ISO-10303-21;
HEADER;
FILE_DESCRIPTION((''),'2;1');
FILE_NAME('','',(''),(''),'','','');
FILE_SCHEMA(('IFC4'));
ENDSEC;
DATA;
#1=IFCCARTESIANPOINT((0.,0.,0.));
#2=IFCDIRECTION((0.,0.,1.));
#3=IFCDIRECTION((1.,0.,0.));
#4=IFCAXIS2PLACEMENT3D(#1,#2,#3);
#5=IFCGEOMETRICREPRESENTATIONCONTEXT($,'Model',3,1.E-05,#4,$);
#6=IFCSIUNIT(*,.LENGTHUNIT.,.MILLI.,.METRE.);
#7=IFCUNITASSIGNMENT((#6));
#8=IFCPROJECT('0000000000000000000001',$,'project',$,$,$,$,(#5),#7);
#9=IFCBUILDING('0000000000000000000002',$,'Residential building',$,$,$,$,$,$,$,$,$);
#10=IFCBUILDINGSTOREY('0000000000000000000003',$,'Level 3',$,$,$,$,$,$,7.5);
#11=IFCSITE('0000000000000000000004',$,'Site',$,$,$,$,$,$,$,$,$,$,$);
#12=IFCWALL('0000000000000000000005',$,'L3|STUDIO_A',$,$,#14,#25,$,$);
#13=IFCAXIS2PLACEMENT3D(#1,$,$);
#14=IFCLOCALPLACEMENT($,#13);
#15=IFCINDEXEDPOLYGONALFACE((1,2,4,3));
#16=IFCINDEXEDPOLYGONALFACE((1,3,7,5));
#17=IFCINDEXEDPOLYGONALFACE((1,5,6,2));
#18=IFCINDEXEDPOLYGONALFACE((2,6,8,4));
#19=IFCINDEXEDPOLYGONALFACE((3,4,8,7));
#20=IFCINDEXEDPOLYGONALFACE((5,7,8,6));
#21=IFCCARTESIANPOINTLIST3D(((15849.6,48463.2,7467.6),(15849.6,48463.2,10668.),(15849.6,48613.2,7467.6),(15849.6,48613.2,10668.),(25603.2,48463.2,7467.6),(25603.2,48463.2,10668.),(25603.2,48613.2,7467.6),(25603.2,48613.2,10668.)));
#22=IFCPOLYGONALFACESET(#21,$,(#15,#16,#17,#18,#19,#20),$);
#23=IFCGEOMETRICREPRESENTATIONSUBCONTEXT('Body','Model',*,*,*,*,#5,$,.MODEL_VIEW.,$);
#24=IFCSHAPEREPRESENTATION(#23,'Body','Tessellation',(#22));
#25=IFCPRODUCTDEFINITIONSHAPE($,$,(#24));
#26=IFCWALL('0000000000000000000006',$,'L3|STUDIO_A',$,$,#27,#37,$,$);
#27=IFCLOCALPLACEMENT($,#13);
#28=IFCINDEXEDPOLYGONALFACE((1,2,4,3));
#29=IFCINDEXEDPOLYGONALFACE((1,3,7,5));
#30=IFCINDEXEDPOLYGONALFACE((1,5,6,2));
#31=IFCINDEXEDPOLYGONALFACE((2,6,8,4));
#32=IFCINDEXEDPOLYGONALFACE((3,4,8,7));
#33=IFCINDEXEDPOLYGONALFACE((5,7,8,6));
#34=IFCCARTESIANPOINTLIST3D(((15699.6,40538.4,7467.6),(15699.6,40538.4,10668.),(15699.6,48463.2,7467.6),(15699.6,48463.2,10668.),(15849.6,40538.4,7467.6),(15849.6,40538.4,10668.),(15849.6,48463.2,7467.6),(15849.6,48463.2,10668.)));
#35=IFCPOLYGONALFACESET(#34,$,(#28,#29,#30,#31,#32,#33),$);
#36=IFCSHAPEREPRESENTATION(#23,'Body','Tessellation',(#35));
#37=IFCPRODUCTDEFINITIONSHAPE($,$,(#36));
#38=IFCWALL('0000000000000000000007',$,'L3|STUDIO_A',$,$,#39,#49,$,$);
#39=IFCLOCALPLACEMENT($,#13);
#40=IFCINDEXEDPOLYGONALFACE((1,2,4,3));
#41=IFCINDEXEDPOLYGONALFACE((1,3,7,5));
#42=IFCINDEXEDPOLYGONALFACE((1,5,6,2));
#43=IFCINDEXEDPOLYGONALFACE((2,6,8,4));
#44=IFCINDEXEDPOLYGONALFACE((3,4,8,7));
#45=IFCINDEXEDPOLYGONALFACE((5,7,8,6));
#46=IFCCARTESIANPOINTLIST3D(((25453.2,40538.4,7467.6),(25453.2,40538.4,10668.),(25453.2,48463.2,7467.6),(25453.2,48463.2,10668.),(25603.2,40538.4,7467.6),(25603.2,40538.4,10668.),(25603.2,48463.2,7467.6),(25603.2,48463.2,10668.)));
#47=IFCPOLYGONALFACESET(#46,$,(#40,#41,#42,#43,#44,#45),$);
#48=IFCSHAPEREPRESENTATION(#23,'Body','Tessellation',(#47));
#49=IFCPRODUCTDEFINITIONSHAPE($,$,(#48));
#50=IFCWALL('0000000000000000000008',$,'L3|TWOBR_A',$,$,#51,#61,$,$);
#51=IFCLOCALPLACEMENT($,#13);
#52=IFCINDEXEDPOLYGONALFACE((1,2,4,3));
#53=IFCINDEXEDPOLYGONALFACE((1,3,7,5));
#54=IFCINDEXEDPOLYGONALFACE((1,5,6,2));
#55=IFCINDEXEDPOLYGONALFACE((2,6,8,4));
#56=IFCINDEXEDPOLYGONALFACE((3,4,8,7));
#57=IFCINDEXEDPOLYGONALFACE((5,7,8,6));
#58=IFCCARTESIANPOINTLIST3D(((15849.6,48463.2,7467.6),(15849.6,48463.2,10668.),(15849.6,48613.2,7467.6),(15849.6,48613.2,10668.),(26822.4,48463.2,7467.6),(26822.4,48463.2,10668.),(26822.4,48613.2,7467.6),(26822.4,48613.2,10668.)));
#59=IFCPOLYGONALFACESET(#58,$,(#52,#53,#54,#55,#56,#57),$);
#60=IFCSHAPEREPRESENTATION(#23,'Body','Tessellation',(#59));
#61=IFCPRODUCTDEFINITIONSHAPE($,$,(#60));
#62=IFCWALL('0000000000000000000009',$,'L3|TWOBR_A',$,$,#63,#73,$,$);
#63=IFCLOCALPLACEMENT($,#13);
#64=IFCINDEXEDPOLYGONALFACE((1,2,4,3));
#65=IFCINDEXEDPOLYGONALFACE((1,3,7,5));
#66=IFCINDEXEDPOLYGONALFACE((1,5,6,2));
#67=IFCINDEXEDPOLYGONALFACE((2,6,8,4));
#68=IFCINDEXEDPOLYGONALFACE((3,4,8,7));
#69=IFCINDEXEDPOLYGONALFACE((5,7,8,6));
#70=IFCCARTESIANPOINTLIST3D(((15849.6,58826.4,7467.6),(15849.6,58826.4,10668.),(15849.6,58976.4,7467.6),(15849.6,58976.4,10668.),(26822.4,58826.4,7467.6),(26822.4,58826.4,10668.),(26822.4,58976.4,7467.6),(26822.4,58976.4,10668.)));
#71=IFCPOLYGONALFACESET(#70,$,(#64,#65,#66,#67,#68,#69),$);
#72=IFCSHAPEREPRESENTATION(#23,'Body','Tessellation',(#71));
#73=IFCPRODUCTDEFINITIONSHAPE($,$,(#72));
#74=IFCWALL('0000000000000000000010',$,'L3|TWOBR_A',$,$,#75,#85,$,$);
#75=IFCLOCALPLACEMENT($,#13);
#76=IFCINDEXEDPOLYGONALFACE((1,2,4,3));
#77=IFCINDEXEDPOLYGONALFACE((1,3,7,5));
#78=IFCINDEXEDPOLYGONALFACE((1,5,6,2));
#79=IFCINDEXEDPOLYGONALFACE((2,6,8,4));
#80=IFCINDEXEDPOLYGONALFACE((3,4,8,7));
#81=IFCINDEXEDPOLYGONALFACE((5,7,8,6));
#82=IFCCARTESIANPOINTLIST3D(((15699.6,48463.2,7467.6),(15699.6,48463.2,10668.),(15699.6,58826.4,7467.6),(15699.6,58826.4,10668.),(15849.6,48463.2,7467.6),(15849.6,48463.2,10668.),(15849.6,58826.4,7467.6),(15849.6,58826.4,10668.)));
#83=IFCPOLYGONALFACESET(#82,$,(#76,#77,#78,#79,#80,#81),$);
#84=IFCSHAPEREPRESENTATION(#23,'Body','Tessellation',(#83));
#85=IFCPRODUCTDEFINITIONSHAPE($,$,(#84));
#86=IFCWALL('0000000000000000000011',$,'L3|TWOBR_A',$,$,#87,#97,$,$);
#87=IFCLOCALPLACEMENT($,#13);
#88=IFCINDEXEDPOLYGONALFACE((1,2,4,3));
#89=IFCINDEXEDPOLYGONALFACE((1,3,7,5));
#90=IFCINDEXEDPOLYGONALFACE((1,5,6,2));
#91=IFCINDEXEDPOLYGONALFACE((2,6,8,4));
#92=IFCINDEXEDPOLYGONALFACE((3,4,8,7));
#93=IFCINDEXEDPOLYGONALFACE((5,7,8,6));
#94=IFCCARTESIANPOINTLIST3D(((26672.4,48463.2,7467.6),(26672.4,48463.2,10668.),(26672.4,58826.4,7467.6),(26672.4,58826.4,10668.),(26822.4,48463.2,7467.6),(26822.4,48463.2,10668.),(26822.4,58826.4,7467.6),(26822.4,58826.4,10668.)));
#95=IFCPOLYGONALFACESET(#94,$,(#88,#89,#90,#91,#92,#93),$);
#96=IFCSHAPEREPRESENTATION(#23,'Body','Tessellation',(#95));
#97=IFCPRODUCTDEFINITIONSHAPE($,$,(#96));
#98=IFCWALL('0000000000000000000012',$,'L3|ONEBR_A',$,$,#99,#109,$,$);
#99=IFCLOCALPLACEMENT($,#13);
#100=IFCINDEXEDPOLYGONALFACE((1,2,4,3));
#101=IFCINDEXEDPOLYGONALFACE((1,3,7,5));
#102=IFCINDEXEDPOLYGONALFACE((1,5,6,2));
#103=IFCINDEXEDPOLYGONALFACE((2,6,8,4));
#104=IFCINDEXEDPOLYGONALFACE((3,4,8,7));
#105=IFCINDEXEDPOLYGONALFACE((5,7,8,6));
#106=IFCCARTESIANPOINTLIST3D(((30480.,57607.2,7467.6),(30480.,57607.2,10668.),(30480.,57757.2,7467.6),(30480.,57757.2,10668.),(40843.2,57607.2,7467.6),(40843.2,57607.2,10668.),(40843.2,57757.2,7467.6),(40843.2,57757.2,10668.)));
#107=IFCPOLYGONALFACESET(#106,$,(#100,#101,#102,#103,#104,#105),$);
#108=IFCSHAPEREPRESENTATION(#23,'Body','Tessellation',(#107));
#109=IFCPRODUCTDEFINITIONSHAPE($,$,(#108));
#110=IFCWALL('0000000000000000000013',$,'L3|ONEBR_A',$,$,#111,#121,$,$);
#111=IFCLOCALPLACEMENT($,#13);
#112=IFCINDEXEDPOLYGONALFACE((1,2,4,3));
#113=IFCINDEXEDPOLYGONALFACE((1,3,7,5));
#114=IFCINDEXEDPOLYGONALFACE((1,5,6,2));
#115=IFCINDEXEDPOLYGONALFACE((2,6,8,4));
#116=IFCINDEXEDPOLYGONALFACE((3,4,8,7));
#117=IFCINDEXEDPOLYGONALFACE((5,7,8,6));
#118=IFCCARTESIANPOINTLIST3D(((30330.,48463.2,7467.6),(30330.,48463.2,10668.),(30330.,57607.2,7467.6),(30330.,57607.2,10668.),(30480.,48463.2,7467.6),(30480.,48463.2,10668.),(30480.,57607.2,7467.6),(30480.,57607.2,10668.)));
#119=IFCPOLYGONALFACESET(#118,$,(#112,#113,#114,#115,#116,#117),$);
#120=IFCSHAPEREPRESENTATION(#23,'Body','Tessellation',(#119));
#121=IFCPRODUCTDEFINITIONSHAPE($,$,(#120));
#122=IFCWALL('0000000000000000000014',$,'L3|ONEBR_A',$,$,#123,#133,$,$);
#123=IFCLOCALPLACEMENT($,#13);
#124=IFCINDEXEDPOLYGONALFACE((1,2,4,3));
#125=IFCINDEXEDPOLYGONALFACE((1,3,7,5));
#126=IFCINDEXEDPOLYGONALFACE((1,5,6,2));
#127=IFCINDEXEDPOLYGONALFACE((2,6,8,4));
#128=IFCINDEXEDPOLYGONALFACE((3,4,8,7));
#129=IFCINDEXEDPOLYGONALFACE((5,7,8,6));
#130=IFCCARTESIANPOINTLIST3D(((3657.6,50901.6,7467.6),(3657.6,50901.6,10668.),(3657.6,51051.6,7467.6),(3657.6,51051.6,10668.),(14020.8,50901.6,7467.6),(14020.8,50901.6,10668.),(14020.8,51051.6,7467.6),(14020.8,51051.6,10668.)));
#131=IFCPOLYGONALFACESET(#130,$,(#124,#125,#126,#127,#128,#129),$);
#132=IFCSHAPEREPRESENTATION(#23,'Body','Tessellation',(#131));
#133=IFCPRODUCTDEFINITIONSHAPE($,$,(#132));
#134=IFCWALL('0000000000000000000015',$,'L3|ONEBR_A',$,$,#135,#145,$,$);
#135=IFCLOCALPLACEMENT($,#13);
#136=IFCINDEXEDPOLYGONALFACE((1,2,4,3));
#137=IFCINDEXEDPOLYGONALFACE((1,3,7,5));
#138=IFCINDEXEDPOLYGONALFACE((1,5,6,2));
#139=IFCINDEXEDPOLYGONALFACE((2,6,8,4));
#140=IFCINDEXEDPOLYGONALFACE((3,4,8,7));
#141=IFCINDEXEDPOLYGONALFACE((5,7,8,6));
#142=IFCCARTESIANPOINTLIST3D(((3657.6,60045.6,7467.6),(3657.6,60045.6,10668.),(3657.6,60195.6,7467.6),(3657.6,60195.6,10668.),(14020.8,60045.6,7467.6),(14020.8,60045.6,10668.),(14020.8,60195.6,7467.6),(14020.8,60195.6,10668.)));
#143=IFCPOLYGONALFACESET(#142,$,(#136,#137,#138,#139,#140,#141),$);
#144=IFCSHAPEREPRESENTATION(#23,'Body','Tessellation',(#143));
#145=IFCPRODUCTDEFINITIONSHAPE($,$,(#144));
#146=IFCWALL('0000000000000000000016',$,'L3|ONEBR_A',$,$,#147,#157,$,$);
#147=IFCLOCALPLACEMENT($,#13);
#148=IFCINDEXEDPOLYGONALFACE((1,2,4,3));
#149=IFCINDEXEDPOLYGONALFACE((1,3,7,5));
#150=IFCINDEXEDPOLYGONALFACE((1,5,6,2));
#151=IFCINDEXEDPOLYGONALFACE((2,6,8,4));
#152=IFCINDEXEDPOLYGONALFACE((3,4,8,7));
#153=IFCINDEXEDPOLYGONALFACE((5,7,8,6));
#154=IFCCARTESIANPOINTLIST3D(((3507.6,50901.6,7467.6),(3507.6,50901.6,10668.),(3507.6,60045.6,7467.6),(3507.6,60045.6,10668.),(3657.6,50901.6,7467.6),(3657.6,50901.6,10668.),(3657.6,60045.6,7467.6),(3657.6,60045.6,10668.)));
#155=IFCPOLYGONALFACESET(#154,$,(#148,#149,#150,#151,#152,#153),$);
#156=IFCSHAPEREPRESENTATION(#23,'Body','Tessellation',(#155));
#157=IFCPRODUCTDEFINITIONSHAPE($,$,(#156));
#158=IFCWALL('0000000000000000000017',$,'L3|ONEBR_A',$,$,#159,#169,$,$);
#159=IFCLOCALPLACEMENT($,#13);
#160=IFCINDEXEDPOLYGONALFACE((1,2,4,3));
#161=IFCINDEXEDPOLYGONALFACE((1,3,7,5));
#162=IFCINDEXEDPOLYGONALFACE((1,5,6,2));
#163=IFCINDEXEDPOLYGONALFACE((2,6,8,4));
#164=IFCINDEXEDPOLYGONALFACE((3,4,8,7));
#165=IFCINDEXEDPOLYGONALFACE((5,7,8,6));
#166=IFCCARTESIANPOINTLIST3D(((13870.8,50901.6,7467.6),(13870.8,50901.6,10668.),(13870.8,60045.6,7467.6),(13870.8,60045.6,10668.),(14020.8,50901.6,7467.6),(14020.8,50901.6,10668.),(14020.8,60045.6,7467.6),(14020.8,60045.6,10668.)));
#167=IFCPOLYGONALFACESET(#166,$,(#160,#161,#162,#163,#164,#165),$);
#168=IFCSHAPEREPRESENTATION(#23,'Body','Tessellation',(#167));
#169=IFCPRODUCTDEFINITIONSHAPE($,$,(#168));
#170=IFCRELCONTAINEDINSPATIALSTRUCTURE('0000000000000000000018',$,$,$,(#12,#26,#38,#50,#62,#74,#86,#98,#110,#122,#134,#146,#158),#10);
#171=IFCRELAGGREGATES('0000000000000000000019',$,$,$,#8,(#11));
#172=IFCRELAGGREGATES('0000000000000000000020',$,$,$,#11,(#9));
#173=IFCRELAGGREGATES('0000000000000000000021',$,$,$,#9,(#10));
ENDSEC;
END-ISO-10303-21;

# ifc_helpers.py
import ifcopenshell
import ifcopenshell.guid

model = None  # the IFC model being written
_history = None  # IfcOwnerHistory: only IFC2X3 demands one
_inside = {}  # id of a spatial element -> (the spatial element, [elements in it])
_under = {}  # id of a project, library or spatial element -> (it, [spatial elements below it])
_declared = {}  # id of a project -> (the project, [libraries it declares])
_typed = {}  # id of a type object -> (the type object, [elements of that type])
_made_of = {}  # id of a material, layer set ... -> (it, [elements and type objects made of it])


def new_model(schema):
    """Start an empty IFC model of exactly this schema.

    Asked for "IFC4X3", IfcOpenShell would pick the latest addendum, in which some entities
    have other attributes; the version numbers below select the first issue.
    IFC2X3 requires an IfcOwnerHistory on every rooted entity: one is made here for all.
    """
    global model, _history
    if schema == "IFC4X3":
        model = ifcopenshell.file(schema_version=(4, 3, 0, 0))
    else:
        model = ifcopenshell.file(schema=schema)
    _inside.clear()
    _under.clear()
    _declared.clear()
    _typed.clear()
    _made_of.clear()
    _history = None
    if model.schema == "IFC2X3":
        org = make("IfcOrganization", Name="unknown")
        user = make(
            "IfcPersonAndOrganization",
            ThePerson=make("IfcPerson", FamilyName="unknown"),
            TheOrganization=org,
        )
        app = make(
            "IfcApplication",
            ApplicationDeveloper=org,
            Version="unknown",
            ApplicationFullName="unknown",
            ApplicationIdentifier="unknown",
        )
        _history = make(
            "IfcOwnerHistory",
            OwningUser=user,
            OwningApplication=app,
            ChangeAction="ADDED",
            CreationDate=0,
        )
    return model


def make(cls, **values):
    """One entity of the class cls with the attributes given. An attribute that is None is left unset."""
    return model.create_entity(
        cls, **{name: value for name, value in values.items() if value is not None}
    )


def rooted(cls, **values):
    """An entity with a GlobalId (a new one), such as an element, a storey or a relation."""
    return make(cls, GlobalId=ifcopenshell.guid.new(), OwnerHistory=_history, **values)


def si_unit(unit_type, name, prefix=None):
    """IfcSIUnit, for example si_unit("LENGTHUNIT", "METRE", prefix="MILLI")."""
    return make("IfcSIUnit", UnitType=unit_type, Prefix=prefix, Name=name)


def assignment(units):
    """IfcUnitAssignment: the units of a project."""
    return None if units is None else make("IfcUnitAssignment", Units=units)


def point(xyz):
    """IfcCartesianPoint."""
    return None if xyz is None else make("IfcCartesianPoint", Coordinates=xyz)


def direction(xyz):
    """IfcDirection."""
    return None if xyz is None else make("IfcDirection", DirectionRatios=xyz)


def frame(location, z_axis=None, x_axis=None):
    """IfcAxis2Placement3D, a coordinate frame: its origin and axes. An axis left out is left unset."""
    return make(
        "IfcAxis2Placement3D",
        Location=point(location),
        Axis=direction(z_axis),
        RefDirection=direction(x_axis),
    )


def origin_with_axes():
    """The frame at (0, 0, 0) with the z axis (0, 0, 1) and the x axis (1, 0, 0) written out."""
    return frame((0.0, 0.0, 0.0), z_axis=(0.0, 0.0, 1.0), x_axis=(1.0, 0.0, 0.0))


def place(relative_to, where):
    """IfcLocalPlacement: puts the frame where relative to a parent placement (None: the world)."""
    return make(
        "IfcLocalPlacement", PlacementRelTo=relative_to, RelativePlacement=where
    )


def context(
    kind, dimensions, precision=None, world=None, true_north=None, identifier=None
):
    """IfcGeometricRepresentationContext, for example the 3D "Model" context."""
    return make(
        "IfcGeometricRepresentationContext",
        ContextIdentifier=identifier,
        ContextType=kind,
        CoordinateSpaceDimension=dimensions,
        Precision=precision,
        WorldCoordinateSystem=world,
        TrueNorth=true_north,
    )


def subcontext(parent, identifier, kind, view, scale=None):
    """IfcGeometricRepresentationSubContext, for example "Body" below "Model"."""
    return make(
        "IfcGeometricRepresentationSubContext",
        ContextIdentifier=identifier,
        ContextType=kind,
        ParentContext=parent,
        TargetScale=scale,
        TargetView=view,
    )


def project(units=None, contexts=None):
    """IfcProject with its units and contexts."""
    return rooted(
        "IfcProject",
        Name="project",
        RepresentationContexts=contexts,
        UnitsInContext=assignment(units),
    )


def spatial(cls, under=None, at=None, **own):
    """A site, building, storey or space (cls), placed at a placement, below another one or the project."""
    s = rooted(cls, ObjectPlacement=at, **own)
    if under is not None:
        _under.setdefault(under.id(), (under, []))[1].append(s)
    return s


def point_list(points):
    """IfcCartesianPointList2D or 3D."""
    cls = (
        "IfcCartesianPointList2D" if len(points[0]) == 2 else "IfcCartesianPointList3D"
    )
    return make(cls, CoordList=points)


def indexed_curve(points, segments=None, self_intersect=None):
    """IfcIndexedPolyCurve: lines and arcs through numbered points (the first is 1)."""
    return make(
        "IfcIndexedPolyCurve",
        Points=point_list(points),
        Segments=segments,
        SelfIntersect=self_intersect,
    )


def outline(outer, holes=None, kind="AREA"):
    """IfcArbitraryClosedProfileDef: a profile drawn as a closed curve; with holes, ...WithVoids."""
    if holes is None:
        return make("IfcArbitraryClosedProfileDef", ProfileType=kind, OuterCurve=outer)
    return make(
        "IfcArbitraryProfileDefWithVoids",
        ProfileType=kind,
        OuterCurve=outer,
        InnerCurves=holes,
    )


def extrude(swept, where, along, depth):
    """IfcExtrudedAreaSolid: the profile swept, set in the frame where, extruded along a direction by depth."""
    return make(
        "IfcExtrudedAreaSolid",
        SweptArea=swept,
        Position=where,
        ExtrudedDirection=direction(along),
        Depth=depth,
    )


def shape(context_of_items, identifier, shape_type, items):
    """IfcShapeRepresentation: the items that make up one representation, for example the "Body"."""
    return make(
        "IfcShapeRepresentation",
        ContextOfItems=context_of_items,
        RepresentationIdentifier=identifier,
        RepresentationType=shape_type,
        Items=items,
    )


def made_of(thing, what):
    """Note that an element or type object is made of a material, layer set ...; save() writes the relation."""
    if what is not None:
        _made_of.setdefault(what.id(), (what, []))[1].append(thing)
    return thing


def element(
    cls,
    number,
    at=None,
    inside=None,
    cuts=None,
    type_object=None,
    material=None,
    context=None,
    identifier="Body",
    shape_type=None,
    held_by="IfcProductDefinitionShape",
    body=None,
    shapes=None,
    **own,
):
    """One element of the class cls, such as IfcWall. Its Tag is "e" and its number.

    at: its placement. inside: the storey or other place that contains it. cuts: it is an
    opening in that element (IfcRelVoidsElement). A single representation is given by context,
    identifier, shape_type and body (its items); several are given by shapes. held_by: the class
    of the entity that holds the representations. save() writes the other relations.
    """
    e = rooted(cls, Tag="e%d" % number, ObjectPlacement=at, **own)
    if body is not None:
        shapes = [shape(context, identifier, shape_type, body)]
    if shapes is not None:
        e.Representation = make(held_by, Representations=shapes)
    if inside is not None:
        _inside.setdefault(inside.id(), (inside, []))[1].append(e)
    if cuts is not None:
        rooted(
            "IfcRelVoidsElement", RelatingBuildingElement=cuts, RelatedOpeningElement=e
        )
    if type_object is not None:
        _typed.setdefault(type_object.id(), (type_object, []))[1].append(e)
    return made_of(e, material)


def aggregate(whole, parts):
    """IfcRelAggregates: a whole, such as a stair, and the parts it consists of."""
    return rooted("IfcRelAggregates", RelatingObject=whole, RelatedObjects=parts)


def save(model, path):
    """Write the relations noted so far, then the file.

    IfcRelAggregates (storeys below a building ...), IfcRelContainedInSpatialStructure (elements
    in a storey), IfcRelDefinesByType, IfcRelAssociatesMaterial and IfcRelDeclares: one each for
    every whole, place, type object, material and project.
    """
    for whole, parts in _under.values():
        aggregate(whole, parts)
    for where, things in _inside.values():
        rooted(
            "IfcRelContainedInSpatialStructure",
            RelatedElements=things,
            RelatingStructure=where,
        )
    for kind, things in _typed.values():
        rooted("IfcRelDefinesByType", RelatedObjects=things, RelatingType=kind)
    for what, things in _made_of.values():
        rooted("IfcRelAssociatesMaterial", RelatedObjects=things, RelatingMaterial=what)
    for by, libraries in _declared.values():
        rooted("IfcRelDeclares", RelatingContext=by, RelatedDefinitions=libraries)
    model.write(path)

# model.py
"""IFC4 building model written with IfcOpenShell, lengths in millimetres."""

from ifc_helpers import new_model, si_unit, frame, origin_with_axes, place, context, subcontext, project, spatial, indexed_curve, outline, extrude, element, save


model = new_model("IFC4")

# Units and contexts
model_context = context("Model", 3, precision=1e-05, world=origin_with_axes())
body_context = subcontext(model_context, "Body", "Model", "MODEL_VIEW")
ifc_project = project(units=[si_unit("LENGTHUNIT", "METRE", prefix="MILLI")], contexts=[model_context])

# Site, building, storey
site = spatial("IfcSite", under=ifc_project, Name="Site")
building = spatial("IfcBuilding", under=site, Name="Residential building")
storey = spatial("IfcBuildingStorey", under=building, Name="Level 3", Elevation=7.5)

# Walls
for number, where, z_axis, x_axis, name in (
    (1, (15849.6, 48463.2, 7467.6), (0.0, 0.0, 1.0), (1.0, 0.0, 0.0), "L3|STUDIO_A"),
):
    element("IfcWall", number, at=place(None, frame(where, z_axis=z_axis, x_axis=x_axis)), inside=storey, Name=name, context=body_context, shape_type="SweptSolid", body=[
        extrude(outline(indexed_curve([(0.0, 0.0), (0.0, 150.0), (9753.6, 150.0), (9753.6, 0.0), (0.0, 0.0)], self_intersect=False)), origin_with_axes(), (0.0, 0.0, 1.0), 3200.4),
    ])
for number, where, z_axis, x_axis, name in (
    (2, (15849.6, 40538.4, 7467.6), (0.0, 0.0, 1.0), (0.0, 1.0, 0.0), "L3|STUDIO_A"),
    (3, (25603.2, 40538.4, 7467.6), (0.0, 0.0, 1.0), (0.0, 1.0, 0.0), "L3|STUDIO_A"),
):
    element("IfcWall", number, at=place(None, frame(where, z_axis=z_axis, x_axis=x_axis)), inside=storey, Name=name, context=body_context, shape_type="SweptSolid", body=[
        extrude(outline(indexed_curve([(0.0, 0.0), (0.0, 150.0), (7924.8, 150.0), (7924.8, 0.0), (0.0, 0.0)], self_intersect=False)), origin_with_axes(), (0.0, 0.0, 1.0), 3200.4),
    ])
for number, where, z_axis, x_axis, name in (
    (4, (15849.6, 48463.2, 7467.6), (0.0, 0.0, 1.0), (1.0, 0.0, 0.0), "L3|TWOBR_A"),
    (5, (15849.6, 58826.4, 7467.6), (0.0, 0.0, 1.0), (1.0, 0.0, 0.0), "L3|TWOBR_A"),
):
    element("IfcWall", number, at=place(None, frame(where, z_axis=z_axis, x_axis=x_axis)), inside=storey, Name=name, context=body_context, shape_type="SweptSolid", body=[
        extrude(outline(indexed_curve([(0.0, 0.0), (0.0, 150.0), (10972.8, 150.0), (10972.8, 0.0), (0.0, 0.0)], self_intersect=False)), origin_with_axes(), (0.0, 0.0, 1.0), 3200.4),
    ])
for number, where, z_axis, x_axis, name in (
    (6, (15849.6, 48463.2, 7467.6), (0.0, 0.0, 1.0), (0.0, 1.0, 0.0), "L3|TWOBR_A"),
    (7, (26822.4, 48463.2, 7467.6), (0.0, 0.0, 1.0), (0.0, 1.0, 0.0), "L3|TWOBR_A"),
    (8, (30480.0, 57607.2, 7467.6), (0.0, 0.0, 1.0), (1.0, 0.0, 0.0), "L3|ONEBR_A"),
):
    element("IfcWall", number, at=place(None, frame(where, z_axis=z_axis, x_axis=x_axis)), inside=storey, Name=name, context=body_context, shape_type="SweptSolid", body=[
        extrude(outline(indexed_curve([(0.0, 0.0), (0.0, 150.0), (10363.2, 150.0), (10363.2, 0.0), (0.0, 0.0)], self_intersect=False)), origin_with_axes(), (0.0, 0.0, 1.0), 3200.4),
    ])
wall_1_placement = place(None, frame((30480.0, 48463.2, 7467.6), z_axis=(0.0, 0.0, 1.0), x_axis=(0.0, 1.0, 0.0)))
element("IfcWall", 9, at=wall_1_placement, inside=storey, Name="L3|ONEBR_A", context=body_context, shape_type="SweptSolid", body=[
    extrude(outline(indexed_curve([(0.0, 0.0), (0.0, 150.0), (9144.0, 150.0), (9144.0, 0.0), (0.0, 0.0)], self_intersect=False)), origin_with_axes(), (0.0, 0.0, 1.0), 3200.4),
])
for number, where, z_axis, x_axis, name in (
    (10, (3657.6, 50901.6, 7467.6), (0.0, 0.0, 1.0), (1.0, 0.0, 0.0), "L3|ONEBR_A"),
    (11, (3657.6, 60045.6, 7467.6), (0.0, 0.0, 1.0), (1.0, 0.0, 0.0), "L3|ONEBR_A"),
):
    element("IfcWall", number, at=place(None, frame(where, z_axis=z_axis, x_axis=x_axis)), inside=storey, Name=name, context=body_context, shape_type="SweptSolid", body=[
        extrude(outline(indexed_curve([(0.0, 0.0), (0.0, 150.0), (10363.2, 150.0), (10363.2, 0.0), (0.0, 0.0)], self_intersect=False)), origin_with_axes(), (0.0, 0.0, 1.0), 3200.4),
    ])
for number, where, z_axis, x_axis, name in (
    (12, (3657.6, 50901.6, 7467.6), (0.0, 0.0, 1.0), (0.0, 1.0, 0.0), "L3|ONEBR_A"),
    (13, (14020.8, 50901.6, 7467.6), (0.0, 0.0, 1.0), (0.0, 1.0, 0.0), "L3|ONEBR_A"),
):
    element("IfcWall", number, at=place(None, frame(where, z_axis=z_axis, x_axis=x_axis)), inside=storey, Name=name, context=body_context, shape_type="SweptSolid", body=[
        extrude(outline(indexed_curve([(0.0, 0.0), (0.0, 150.0), (9144.0, 150.0), (9144.0, 0.0), (0.0, 0.0)], self_intersect=False)), origin_with_axes(), (0.0, 0.0, 1.0), 3200.4),
    ])

save(model, "model.ifc")
